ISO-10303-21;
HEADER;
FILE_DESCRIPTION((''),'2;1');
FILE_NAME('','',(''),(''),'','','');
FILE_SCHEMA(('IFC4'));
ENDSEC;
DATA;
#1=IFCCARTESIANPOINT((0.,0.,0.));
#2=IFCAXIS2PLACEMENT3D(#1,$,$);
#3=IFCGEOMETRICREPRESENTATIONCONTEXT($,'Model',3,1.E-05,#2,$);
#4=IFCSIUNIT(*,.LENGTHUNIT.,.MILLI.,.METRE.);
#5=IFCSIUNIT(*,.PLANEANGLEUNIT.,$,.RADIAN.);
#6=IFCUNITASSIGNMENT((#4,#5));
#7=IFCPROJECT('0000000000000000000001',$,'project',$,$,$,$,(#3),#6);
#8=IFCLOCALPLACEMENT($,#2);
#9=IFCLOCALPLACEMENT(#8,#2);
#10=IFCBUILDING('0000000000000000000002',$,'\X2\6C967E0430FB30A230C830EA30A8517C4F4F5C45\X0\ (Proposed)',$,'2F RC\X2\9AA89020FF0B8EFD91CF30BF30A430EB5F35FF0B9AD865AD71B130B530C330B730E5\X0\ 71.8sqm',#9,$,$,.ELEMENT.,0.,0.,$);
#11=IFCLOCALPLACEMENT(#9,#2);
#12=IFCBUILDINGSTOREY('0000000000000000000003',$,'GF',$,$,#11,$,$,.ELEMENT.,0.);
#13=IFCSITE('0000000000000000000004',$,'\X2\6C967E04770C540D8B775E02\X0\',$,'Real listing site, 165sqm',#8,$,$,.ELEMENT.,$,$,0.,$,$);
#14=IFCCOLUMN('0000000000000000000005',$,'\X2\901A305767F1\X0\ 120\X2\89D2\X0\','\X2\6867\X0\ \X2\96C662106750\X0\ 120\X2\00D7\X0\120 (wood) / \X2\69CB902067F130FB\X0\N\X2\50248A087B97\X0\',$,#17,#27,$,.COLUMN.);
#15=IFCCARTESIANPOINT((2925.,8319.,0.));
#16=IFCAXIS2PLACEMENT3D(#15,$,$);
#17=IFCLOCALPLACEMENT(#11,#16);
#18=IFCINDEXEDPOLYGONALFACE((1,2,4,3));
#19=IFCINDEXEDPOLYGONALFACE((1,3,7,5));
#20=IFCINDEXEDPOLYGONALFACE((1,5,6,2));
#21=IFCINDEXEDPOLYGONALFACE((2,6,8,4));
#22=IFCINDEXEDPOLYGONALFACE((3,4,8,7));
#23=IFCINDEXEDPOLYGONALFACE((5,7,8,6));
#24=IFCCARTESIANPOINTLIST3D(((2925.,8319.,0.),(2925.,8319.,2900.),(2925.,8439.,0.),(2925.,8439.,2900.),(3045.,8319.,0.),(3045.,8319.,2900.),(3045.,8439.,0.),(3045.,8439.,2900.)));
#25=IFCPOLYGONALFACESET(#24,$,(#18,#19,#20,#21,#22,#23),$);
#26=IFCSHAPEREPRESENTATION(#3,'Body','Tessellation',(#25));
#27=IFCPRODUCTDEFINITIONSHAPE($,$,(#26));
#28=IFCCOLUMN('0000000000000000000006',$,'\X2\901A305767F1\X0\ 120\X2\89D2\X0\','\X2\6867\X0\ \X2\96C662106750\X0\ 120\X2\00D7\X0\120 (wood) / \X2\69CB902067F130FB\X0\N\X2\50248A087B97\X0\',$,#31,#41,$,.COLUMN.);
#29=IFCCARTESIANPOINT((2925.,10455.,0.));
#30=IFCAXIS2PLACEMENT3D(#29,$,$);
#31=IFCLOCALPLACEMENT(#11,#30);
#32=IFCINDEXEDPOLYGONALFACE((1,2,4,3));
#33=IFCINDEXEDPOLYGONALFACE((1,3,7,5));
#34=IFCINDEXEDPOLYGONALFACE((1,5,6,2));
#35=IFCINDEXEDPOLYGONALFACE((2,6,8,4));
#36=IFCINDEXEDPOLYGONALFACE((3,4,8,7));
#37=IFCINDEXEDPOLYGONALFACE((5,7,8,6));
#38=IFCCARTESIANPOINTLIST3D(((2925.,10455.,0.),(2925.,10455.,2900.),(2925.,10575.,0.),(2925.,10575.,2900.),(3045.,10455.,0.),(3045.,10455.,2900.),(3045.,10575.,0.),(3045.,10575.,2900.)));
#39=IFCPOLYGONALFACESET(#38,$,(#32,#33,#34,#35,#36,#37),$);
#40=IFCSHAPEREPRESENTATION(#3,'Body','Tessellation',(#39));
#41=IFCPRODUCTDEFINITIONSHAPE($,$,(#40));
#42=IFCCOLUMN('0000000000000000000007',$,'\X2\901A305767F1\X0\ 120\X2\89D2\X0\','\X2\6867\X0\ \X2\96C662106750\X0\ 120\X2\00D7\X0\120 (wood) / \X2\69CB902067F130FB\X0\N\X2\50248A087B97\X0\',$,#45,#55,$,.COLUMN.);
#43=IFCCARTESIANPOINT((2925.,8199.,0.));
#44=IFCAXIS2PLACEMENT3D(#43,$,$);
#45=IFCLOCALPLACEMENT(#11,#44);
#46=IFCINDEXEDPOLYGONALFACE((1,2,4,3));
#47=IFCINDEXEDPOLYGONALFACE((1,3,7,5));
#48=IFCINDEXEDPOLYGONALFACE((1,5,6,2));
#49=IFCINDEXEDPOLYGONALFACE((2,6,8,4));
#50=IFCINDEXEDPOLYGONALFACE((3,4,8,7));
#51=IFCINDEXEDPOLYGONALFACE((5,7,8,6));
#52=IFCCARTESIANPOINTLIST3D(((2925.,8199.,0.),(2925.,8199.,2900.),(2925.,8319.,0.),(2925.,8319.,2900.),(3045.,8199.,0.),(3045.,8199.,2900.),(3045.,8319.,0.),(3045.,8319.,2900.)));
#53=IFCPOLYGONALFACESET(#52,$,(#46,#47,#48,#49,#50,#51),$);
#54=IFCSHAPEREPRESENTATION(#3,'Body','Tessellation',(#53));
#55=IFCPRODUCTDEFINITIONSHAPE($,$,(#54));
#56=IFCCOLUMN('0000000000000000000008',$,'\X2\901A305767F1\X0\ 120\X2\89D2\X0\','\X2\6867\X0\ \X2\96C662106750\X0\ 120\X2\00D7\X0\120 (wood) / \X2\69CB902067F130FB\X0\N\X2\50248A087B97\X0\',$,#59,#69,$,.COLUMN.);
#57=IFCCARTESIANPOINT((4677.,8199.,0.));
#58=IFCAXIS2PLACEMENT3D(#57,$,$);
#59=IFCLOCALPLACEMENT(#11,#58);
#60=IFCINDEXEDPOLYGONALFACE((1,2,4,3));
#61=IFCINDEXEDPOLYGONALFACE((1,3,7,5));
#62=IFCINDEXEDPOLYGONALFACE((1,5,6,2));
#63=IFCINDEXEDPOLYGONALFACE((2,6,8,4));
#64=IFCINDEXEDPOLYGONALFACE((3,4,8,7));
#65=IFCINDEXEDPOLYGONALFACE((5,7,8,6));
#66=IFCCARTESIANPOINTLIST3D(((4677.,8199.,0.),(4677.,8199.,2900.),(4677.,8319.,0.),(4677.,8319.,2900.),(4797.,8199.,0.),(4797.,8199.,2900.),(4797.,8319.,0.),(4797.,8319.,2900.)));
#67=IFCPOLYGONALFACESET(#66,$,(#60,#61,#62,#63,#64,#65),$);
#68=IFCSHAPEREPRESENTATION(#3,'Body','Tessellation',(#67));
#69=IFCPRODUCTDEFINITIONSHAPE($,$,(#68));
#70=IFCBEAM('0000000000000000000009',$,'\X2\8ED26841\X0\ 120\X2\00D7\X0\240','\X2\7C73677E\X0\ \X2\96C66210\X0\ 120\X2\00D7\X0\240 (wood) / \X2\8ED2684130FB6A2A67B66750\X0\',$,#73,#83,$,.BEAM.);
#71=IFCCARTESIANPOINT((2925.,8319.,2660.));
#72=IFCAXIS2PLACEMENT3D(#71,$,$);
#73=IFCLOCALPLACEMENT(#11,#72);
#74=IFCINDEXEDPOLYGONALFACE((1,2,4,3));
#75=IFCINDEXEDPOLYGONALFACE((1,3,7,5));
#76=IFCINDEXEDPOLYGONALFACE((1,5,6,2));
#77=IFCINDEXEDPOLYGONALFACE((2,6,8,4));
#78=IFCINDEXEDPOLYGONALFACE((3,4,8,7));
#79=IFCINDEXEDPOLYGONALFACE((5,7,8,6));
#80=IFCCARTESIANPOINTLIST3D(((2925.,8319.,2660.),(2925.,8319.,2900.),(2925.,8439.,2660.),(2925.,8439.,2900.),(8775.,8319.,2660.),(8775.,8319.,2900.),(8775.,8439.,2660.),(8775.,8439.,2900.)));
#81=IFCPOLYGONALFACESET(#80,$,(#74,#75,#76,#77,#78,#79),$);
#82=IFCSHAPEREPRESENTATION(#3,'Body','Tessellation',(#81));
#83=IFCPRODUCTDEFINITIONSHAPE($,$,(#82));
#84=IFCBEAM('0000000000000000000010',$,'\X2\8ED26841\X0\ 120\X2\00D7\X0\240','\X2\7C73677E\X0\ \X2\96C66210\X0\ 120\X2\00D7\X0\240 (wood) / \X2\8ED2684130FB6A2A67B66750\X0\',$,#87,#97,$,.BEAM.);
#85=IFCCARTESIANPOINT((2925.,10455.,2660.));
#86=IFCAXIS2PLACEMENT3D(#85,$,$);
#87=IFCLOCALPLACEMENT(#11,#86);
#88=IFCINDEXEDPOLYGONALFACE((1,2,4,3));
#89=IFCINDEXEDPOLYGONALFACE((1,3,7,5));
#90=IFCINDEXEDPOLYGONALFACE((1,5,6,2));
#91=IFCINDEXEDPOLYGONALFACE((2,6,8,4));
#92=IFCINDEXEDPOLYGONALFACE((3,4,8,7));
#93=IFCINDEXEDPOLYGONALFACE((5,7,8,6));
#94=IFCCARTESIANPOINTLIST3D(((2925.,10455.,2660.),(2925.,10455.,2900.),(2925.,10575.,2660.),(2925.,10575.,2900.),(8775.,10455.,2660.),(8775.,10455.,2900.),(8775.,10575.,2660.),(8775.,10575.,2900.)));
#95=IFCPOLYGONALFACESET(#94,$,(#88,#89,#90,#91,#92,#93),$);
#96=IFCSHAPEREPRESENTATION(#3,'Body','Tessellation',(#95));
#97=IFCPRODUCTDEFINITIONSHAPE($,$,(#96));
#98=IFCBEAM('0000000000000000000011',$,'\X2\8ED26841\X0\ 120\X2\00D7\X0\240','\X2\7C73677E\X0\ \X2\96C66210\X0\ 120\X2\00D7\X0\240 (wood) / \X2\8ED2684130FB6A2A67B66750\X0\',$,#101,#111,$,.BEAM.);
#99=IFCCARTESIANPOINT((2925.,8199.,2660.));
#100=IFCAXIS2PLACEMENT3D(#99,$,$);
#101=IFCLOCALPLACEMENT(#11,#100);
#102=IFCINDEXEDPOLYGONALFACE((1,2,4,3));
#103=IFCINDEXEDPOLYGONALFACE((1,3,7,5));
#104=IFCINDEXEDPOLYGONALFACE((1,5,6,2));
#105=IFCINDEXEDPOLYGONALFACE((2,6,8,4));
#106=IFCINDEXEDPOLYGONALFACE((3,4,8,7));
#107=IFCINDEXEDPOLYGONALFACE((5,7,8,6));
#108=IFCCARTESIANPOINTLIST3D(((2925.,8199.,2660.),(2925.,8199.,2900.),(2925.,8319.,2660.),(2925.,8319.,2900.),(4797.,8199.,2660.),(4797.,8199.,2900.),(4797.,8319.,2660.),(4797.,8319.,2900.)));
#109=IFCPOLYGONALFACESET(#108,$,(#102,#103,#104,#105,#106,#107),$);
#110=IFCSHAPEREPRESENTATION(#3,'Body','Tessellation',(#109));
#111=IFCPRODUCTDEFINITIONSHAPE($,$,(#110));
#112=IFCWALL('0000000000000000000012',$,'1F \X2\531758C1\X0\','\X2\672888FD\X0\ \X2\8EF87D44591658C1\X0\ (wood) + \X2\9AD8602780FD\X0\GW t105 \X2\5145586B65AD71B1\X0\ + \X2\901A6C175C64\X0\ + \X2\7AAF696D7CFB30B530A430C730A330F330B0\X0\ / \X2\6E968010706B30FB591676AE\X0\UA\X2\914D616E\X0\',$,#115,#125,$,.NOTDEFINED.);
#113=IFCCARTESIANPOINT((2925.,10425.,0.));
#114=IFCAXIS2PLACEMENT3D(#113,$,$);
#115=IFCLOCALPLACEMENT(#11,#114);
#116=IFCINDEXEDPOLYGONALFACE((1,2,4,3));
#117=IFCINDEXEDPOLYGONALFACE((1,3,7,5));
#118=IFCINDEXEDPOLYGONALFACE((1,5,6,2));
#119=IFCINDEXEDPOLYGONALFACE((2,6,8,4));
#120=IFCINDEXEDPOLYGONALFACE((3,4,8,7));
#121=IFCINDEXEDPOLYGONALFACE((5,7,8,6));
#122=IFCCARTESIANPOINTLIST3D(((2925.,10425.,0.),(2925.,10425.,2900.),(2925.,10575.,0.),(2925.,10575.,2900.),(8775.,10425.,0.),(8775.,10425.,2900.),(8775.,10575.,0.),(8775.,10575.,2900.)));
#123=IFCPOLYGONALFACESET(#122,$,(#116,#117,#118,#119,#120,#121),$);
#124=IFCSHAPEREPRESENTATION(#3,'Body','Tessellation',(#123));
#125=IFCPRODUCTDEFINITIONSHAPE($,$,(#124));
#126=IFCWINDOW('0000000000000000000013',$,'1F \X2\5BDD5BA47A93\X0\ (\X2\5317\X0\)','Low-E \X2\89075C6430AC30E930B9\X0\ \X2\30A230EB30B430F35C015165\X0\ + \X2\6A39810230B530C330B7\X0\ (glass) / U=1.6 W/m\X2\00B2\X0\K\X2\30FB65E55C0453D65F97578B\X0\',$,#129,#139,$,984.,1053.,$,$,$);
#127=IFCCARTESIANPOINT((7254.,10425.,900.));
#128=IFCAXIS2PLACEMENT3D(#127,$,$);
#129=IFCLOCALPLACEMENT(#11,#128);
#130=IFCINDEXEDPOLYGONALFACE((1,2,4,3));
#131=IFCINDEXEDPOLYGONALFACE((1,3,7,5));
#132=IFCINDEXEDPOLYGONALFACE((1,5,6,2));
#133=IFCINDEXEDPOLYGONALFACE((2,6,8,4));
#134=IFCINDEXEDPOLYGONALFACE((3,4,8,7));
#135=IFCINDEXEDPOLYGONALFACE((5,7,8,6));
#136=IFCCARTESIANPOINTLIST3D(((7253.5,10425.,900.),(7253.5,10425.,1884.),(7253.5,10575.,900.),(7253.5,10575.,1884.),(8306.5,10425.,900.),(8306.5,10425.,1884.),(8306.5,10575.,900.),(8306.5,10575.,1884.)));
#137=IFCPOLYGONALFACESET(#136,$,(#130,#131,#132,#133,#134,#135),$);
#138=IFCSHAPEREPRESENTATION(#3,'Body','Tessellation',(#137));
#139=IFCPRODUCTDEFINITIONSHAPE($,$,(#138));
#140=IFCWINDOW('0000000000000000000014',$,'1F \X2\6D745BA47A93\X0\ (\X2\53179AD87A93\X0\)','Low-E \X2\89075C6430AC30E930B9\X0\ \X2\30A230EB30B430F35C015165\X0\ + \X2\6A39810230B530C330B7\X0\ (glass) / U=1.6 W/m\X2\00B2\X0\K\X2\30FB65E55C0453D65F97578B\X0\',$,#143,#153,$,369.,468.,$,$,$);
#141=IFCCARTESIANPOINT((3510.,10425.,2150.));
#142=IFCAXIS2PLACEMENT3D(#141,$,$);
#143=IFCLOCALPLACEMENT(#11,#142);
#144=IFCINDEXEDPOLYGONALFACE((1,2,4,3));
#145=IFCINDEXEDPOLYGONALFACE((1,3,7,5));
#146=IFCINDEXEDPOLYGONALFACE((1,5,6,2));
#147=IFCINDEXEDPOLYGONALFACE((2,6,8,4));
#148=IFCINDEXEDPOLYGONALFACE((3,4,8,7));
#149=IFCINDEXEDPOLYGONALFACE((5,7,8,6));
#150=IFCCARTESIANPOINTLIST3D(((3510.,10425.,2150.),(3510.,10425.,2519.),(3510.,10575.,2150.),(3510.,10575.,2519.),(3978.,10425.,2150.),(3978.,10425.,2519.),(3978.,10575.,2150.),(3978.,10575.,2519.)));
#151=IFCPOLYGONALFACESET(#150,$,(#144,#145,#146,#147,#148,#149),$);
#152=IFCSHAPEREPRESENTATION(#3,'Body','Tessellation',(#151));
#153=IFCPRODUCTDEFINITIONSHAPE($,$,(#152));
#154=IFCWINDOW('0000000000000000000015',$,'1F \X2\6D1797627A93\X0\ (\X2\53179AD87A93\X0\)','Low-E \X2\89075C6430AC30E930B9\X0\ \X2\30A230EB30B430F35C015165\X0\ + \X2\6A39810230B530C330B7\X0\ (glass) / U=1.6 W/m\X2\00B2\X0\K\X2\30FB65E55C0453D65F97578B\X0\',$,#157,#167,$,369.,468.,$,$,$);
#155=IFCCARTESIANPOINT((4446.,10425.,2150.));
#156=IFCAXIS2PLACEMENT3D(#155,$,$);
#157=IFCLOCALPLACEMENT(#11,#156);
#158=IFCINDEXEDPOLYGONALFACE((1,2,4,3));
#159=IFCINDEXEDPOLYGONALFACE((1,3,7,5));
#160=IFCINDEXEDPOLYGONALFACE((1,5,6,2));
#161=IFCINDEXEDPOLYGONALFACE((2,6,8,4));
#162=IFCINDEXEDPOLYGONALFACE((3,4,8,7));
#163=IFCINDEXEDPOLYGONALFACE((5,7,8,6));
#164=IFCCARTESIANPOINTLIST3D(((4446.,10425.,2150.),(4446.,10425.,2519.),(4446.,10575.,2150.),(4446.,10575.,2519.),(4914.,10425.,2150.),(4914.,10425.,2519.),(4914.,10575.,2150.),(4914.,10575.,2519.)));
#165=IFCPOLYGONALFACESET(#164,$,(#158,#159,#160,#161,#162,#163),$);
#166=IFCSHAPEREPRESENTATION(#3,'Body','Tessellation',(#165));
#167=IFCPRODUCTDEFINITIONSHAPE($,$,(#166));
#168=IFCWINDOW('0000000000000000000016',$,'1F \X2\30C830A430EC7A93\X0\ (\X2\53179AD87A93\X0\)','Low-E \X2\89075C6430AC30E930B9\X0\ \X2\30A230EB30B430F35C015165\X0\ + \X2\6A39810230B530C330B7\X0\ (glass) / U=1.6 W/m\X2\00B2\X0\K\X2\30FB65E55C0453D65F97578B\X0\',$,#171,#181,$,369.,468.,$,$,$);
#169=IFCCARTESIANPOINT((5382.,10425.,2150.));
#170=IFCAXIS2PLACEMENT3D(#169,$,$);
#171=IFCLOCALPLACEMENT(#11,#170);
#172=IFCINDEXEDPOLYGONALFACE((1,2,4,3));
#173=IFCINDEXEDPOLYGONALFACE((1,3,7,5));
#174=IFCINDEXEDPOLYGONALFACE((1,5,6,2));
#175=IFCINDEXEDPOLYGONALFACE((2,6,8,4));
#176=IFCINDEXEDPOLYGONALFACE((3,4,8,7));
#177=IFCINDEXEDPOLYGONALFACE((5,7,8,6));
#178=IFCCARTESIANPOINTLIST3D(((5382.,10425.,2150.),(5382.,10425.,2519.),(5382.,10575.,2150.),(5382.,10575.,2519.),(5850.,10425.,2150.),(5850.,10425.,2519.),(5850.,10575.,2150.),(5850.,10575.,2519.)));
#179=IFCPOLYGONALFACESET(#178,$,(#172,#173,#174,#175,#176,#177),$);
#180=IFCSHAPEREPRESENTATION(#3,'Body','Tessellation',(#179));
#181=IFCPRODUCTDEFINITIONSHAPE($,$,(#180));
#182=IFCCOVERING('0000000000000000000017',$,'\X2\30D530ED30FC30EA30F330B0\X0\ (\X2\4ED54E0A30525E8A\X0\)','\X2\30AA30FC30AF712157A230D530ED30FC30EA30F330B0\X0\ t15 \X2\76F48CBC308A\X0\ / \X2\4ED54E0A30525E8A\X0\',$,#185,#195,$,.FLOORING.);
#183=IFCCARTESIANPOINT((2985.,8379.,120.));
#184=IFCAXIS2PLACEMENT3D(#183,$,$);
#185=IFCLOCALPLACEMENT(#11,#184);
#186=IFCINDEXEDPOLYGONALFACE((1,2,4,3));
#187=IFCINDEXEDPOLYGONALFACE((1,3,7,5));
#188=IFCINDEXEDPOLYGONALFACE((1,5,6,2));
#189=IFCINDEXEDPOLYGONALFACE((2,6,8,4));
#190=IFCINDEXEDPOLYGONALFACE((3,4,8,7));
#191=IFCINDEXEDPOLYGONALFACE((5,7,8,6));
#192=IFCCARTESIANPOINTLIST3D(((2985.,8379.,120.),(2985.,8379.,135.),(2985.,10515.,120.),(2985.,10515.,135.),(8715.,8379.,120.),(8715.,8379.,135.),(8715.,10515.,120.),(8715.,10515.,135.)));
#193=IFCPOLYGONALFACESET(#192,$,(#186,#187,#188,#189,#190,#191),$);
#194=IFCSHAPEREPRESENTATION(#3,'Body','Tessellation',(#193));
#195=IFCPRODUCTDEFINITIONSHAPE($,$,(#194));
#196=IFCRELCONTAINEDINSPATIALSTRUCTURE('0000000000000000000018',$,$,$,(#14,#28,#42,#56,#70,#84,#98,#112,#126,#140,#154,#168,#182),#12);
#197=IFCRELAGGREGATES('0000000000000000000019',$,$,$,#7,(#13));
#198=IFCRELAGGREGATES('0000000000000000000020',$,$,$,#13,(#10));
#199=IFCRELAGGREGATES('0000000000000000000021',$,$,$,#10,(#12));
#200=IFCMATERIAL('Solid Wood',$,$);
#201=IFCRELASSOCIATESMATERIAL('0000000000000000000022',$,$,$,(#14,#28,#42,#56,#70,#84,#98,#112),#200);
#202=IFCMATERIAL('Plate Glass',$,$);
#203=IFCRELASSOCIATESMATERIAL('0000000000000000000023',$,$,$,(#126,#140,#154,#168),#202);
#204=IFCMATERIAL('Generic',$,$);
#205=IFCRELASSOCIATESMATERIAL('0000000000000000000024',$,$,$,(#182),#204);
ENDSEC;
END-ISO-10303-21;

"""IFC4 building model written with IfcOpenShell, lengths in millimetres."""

from ifc_helpers import new_model, si_unit, frame, frame_2d, origin, place, context, project, spatial, rectangle, extrude, material, element, fill, save


model = new_model("IFC4")

# Units and contexts
model_context = context("Model", 3, precision=1e-05, world=origin())
ifc_project = project(units=[si_unit("LENGTHUNIT", "METRE", prefix="MILLI"), si_unit("PLANEANGLEUNIT", "RADIAN")], contexts=[model_context])

# Site, building, storey
site_placement = place(None, origin())
site = spatial("IfcSite", under=ifc_project, at=site_placement, Name="沖縄県名護市", ObjectType="Real listing site, 165sqm", CompositionType="ELEMENT", RefElevation=0.0)
building_placement = place(site_placement, origin())
building = spatial("IfcBuilding", under=site, at=building_placement, Name="沖縄・アトリエ兼住居 (Proposed)", ObjectType="2F RC骨造＋軽量タイル張＋高断熱サッシュ 71.8sqm", CompositionType="ELEMENT", ElevationOfRefHeight=0.0, ElevationOfTerrain=0.0)
storey_placement = place(building_placement, origin())
storey = spatial("IfcBuildingStorey", under=building, at=storey_placement, Name="GF", CompositionType="ELEMENT", Elevation=0.0)

# Columns
ifc_material_1 = material(Name="Solid Wood")
column_1_placement = place(storey_placement, frame((2925.0, 8319.0, 0.0)))
element("IfcColumn", 1, at=column_1_placement, inside=storey, material=ifc_material_1, Name="通し柱 120角", Description="桧 集成材 120×120 (wood) / 構造柱・N値計算", PredefinedType="COLUMN", context=model_context, shape_type="SweptSolid", body=[
    extrude(rectangle(XDim=120.0, YDim=120.0, at=frame_2d((60.0, 60.0))), frame((2925.0, 8319.0, 0.0)), (0.0, 0.0, 1.0), 2900.0),
])
column_2_placement = place(storey_placement, frame((2925.0, 10455.0, 0.0)))
element("IfcColumn", 2, at=column_2_placement, inside=storey, material=ifc_material_1, Name="通し柱 120角", Description="桧 集成材 120×120 (wood) / 構造柱・N値計算", PredefinedType="COLUMN", context=model_context, shape_type="SweptSolid", body=[
    extrude(rectangle(XDim=120.0, YDim=120.0, at=frame_2d((60.0, 60.0))), frame((2925.0, 10455.0, 0.0)), (0.0, 0.0, 1.0), 2900.0),
])
column_3_placement = place(storey_placement, frame((2925.0, 8199.0, 0.0)))
element("IfcColumn", 3, at=column_3_placement, inside=storey, material=ifc_material_1, Name="通し柱 120角", Description="桧 集成材 120×120 (wood) / 構造柱・N値計算", PredefinedType="COLUMN", context=model_context, shape_type="SweptSolid", body=[
    extrude(rectangle(XDim=120.0, YDim=120.0, at=frame_2d((60.0, 60.0))), frame((2925.0, 8199.0, 0.0)), (0.0, 0.0, 1.0), 2900.0),
])
column_4_placement = place(storey_placement, frame((4677.0, 8199.0, 0.0)))
element("IfcColumn", 4, at=column_4_placement, inside=storey, material=ifc_material_1, Name="通し柱 120角", Description="桧 集成材 120×120 (wood) / 構造柱・N値計算", PredefinedType="COLUMN", context=model_context, shape_type="SweptSolid", body=[
    extrude(rectangle(XDim=120.0, YDim=120.0, at=frame_2d((60.0, 60.0))), frame((4677.0, 8199.0, 0.0)), (0.0, 0.0, 1.0), 2900.0),
])

# Beams
beam_1_placement = place(storey_placement, frame((2925.0, 8319.0, 2660.0)))
element("IfcBeam", 5, at=beam_1_placement, inside=storey, material=ifc_material_1, Name="軒桁 120×240", Description="米松 集成 120×240 (wood) / 軒桁・横架材", PredefinedType="BEAM", context=model_context, shape_type="SweptSolid", body=[
    extrude(rectangle(XDim=5850.0, YDim=120.0, at=frame_2d((2925.0, 60.0))), frame((2925.0, 8319.0, 2660.0)), (0.0, 0.0, 1.0), 240.0),
])
beam_2_placement = place(storey_placement, frame((2925.0, 10455.0, 2660.0)))
element("IfcBeam", 6, at=beam_2_placement, inside=storey, material=ifc_material_1, Name="軒桁 120×240", Description="米松 集成 120×240 (wood) / 軒桁・横架材", PredefinedType="BEAM", context=model_context, shape_type="SweptSolid", body=[
    extrude(rectangle(XDim=5850.0, YDim=120.0, at=frame_2d((2925.0, 60.0))), frame((2925.0, 10455.0, 2660.0)), (0.0, 0.0, 1.0), 240.0),
])
beam_3_placement = place(storey_placement, frame((2925.0, 8199.0, 2660.0)))
element("IfcBeam", 7, at=beam_3_placement, inside=storey, material=ifc_material_1, Name="軒桁 120×240", Description="米松 集成 120×240 (wood) / 軒桁・横架材", PredefinedType="BEAM", context=model_context, shape_type="SweptSolid", body=[
    extrude(rectangle(XDim=1872.0, YDim=120.0, at=frame_2d((936.0, 60.0))), frame((2925.0, 8199.0, 2660.0)), (0.0, 0.0, 1.0), 240.0),
])

# Wall, openings, windows
wall_1_placement = place(storey_placement, frame((2925.0, 10425.0, 0.0)))
wall_1 = element("IfcWall", 8, at=wall_1_placement, inside=storey, material=ifc_material_1, Name="1F 北壁", Description="木製 軸組外壁 (wood) + 高性能GW t105 充填断熱 + 通気層 + 窯業系サイディング / 準耐火・外皮UA配慮", PredefinedType="NOTDEFINED", context=model_context, shape_type="SweptSolid", body=[
    extrude(rectangle(XDim=5850.0, YDim=150.0, at=frame_2d((2925.0, 75.0))), frame((2925.0, 10425.0, 0.0)), (0.0, 0.0, 1.0), 2900.0),
])
opening_1_placement = place(storey_placement, frame((7254.0, 10425.0, 900.0)))
opening_1 = element("IfcOpeningElement", 9, at=opening_1_placement, cuts=wall_1, PredefinedType="NOTDEFINED", context=model_context, shape_type="SweptSolid", body=[
    extrude(rectangle(XDim=1053.0, YDim=150.0, at=frame_2d((526.0, 75.0))), frame((7254.0, 10425.0, 900.0)), (0.0, 0.0, 1.0), 984.0),
])
opening_2_placement = place(storey_placement, frame((3510.0, 10425.0, 2150.0)))
opening_2 = element("IfcOpeningElement", 10, at=opening_2_placement, cuts=wall_1, PredefinedType="NOTDEFINED", context=model_context, shape_type="SweptSolid", body=[
    extrude(rectangle(XDim=468.0, YDim=150.0, at=frame_2d((234.0, 75.0))), frame((3510.0, 10425.0, 2150.0)), (0.0, 0.0, 1.0), 369.0),
])
opening_3_placement = place(storey_placement, frame((4446.0, 10425.0, 2150.0)))
opening_3 = element("IfcOpeningElement", 11, at=opening_3_placement, cuts=wall_1, PredefinedType="NOTDEFINED", context=model_context, shape_type="SweptSolid", body=[
    extrude(rectangle(XDim=468.0, YDim=150.0, at=frame_2d((234.0, 75.0))), frame((4446.0, 10425.0, 2150.0)), (0.0, 0.0, 1.0), 369.0),
])
opening_4_placement = place(storey_placement, frame((5382.0, 10425.0, 2150.0)))
opening_4 = element("IfcOpeningElement", 12, at=opening_4_placement, cuts=wall_1, PredefinedType="NOTDEFINED", context=model_context, shape_type="SweptSolid", body=[
    extrude(rectangle(XDim=468.0, YDim=150.0, at=frame_2d((234.0, 75.0))), frame((5382.0, 10425.0, 2150.0)), (0.0, 0.0, 1.0), 369.0),
])
ifc_material_2 = material(Name="Plate Glass")
window_1_placement = place(storey_placement, frame((7254.0, 10425.0, 900.0)))
window_1 = element("IfcWindow", 13, at=window_1_placement, inside=storey, material=ifc_material_2, Name="1F 寝室窓 (北)", Description="Low-E 複層ガラス アルゴン封入 + 樹脂サッシ (glass) / U=1.6 W/m²K・日射取得型", OverallHeight=984.0, OverallWidth=1053.0, context=model_context, shape_type="SweptSolid", body=[
    extrude(rectangle(XDim=1053.0, YDim=150.0, at=frame_2d((526.0, 75.0))), frame((7254.0, 10425.0, 900.0)), (0.0, 0.0, 1.0), 984.0),
])
fill(opening_1, window_1)
window_2_placement = place(storey_placement, frame((3510.0, 10425.0, 2150.0)))
window_2 = element("IfcWindow", 14, at=window_2_placement, inside=storey, material=ifc_material_2, Name="1F 浴室窓 (北高窓)", Description="Low-E 複層ガラス アルゴン封入 + 樹脂サッシ (glass) / U=1.6 W/m²K・日射取得型", OverallHeight=369.0, OverallWidth=468.0, context=model_context, shape_type="SweptSolid", body=[
    extrude(rectangle(XDim=468.0, YDim=150.0, at=frame_2d((234.0, 75.0))), frame((3510.0, 10425.0, 2150.0)), (0.0, 0.0, 1.0), 369.0),
])
fill(opening_2, window_2)
window_3_placement = place(storey_placement, frame((4446.0, 10425.0, 2150.0)))
window_3 = element("IfcWindow", 15, at=window_3_placement, inside=storey, material=ifc_material_2, Name="1F 洗面窓 (北高窓)", Description="Low-E 複層ガラス アルゴン封入 + 樹脂サッシ (glass) / U=1.6 W/m²K・日射取得型", OverallHeight=369.0, OverallWidth=468.0, context=model_context, shape_type="SweptSolid", body=[
    extrude(rectangle(XDim=468.0, YDim=150.0, at=frame_2d((234.0, 75.0))), frame((4446.0, 10425.0, 2150.0)), (0.0, 0.0, 1.0), 369.0),
])
fill(opening_3, window_3)
window_4_placement = place(storey_placement, frame((5382.0, 10425.0, 2150.0)))
window_4 = element("IfcWindow", 16, at=window_4_placement, inside=storey, material=ifc_material_2, Name="1F トイレ窓 (北高窓)", Description="Low-E 複層ガラス アルゴン封入 + 樹脂サッシ (glass) / U=1.6 W/m²K・日射取得型", OverallHeight=369.0, OverallWidth=468.0, context=model_context, shape_type="SweptSolid", body=[
    extrude(rectangle(XDim=468.0, YDim=150.0, at=frame_2d((234.0, 75.0))), frame((5382.0, 10425.0, 2150.0)), (0.0, 0.0, 1.0), 369.0),
])
fill(opening_4, window_4)

# Covering
ifc_material_3 = material(Name="Generic")
covering_1_placement = place(storey_placement, frame((2985.0, 8379.0, 120.0)))
element("IfcCovering", 17, at=covering_1_placement, inside=storey, material=ifc_material_3, Name="フローリング (仕上げ床)", Description="オーク無垢フローリング t15 直貼り / 仕上げ床", PredefinedType="FLOORING", context=model_context, shape_type="SweptSolid", body=[
    extrude(rectangle(XDim=5730.0, YDim=2136.0, at=frame_2d((2865.0, 1068.0))), frame((2985.0, 8379.0, 120.0)), (0.0, 0.0, 1.0), 15.0),
])

save(model, "model.ifc")
